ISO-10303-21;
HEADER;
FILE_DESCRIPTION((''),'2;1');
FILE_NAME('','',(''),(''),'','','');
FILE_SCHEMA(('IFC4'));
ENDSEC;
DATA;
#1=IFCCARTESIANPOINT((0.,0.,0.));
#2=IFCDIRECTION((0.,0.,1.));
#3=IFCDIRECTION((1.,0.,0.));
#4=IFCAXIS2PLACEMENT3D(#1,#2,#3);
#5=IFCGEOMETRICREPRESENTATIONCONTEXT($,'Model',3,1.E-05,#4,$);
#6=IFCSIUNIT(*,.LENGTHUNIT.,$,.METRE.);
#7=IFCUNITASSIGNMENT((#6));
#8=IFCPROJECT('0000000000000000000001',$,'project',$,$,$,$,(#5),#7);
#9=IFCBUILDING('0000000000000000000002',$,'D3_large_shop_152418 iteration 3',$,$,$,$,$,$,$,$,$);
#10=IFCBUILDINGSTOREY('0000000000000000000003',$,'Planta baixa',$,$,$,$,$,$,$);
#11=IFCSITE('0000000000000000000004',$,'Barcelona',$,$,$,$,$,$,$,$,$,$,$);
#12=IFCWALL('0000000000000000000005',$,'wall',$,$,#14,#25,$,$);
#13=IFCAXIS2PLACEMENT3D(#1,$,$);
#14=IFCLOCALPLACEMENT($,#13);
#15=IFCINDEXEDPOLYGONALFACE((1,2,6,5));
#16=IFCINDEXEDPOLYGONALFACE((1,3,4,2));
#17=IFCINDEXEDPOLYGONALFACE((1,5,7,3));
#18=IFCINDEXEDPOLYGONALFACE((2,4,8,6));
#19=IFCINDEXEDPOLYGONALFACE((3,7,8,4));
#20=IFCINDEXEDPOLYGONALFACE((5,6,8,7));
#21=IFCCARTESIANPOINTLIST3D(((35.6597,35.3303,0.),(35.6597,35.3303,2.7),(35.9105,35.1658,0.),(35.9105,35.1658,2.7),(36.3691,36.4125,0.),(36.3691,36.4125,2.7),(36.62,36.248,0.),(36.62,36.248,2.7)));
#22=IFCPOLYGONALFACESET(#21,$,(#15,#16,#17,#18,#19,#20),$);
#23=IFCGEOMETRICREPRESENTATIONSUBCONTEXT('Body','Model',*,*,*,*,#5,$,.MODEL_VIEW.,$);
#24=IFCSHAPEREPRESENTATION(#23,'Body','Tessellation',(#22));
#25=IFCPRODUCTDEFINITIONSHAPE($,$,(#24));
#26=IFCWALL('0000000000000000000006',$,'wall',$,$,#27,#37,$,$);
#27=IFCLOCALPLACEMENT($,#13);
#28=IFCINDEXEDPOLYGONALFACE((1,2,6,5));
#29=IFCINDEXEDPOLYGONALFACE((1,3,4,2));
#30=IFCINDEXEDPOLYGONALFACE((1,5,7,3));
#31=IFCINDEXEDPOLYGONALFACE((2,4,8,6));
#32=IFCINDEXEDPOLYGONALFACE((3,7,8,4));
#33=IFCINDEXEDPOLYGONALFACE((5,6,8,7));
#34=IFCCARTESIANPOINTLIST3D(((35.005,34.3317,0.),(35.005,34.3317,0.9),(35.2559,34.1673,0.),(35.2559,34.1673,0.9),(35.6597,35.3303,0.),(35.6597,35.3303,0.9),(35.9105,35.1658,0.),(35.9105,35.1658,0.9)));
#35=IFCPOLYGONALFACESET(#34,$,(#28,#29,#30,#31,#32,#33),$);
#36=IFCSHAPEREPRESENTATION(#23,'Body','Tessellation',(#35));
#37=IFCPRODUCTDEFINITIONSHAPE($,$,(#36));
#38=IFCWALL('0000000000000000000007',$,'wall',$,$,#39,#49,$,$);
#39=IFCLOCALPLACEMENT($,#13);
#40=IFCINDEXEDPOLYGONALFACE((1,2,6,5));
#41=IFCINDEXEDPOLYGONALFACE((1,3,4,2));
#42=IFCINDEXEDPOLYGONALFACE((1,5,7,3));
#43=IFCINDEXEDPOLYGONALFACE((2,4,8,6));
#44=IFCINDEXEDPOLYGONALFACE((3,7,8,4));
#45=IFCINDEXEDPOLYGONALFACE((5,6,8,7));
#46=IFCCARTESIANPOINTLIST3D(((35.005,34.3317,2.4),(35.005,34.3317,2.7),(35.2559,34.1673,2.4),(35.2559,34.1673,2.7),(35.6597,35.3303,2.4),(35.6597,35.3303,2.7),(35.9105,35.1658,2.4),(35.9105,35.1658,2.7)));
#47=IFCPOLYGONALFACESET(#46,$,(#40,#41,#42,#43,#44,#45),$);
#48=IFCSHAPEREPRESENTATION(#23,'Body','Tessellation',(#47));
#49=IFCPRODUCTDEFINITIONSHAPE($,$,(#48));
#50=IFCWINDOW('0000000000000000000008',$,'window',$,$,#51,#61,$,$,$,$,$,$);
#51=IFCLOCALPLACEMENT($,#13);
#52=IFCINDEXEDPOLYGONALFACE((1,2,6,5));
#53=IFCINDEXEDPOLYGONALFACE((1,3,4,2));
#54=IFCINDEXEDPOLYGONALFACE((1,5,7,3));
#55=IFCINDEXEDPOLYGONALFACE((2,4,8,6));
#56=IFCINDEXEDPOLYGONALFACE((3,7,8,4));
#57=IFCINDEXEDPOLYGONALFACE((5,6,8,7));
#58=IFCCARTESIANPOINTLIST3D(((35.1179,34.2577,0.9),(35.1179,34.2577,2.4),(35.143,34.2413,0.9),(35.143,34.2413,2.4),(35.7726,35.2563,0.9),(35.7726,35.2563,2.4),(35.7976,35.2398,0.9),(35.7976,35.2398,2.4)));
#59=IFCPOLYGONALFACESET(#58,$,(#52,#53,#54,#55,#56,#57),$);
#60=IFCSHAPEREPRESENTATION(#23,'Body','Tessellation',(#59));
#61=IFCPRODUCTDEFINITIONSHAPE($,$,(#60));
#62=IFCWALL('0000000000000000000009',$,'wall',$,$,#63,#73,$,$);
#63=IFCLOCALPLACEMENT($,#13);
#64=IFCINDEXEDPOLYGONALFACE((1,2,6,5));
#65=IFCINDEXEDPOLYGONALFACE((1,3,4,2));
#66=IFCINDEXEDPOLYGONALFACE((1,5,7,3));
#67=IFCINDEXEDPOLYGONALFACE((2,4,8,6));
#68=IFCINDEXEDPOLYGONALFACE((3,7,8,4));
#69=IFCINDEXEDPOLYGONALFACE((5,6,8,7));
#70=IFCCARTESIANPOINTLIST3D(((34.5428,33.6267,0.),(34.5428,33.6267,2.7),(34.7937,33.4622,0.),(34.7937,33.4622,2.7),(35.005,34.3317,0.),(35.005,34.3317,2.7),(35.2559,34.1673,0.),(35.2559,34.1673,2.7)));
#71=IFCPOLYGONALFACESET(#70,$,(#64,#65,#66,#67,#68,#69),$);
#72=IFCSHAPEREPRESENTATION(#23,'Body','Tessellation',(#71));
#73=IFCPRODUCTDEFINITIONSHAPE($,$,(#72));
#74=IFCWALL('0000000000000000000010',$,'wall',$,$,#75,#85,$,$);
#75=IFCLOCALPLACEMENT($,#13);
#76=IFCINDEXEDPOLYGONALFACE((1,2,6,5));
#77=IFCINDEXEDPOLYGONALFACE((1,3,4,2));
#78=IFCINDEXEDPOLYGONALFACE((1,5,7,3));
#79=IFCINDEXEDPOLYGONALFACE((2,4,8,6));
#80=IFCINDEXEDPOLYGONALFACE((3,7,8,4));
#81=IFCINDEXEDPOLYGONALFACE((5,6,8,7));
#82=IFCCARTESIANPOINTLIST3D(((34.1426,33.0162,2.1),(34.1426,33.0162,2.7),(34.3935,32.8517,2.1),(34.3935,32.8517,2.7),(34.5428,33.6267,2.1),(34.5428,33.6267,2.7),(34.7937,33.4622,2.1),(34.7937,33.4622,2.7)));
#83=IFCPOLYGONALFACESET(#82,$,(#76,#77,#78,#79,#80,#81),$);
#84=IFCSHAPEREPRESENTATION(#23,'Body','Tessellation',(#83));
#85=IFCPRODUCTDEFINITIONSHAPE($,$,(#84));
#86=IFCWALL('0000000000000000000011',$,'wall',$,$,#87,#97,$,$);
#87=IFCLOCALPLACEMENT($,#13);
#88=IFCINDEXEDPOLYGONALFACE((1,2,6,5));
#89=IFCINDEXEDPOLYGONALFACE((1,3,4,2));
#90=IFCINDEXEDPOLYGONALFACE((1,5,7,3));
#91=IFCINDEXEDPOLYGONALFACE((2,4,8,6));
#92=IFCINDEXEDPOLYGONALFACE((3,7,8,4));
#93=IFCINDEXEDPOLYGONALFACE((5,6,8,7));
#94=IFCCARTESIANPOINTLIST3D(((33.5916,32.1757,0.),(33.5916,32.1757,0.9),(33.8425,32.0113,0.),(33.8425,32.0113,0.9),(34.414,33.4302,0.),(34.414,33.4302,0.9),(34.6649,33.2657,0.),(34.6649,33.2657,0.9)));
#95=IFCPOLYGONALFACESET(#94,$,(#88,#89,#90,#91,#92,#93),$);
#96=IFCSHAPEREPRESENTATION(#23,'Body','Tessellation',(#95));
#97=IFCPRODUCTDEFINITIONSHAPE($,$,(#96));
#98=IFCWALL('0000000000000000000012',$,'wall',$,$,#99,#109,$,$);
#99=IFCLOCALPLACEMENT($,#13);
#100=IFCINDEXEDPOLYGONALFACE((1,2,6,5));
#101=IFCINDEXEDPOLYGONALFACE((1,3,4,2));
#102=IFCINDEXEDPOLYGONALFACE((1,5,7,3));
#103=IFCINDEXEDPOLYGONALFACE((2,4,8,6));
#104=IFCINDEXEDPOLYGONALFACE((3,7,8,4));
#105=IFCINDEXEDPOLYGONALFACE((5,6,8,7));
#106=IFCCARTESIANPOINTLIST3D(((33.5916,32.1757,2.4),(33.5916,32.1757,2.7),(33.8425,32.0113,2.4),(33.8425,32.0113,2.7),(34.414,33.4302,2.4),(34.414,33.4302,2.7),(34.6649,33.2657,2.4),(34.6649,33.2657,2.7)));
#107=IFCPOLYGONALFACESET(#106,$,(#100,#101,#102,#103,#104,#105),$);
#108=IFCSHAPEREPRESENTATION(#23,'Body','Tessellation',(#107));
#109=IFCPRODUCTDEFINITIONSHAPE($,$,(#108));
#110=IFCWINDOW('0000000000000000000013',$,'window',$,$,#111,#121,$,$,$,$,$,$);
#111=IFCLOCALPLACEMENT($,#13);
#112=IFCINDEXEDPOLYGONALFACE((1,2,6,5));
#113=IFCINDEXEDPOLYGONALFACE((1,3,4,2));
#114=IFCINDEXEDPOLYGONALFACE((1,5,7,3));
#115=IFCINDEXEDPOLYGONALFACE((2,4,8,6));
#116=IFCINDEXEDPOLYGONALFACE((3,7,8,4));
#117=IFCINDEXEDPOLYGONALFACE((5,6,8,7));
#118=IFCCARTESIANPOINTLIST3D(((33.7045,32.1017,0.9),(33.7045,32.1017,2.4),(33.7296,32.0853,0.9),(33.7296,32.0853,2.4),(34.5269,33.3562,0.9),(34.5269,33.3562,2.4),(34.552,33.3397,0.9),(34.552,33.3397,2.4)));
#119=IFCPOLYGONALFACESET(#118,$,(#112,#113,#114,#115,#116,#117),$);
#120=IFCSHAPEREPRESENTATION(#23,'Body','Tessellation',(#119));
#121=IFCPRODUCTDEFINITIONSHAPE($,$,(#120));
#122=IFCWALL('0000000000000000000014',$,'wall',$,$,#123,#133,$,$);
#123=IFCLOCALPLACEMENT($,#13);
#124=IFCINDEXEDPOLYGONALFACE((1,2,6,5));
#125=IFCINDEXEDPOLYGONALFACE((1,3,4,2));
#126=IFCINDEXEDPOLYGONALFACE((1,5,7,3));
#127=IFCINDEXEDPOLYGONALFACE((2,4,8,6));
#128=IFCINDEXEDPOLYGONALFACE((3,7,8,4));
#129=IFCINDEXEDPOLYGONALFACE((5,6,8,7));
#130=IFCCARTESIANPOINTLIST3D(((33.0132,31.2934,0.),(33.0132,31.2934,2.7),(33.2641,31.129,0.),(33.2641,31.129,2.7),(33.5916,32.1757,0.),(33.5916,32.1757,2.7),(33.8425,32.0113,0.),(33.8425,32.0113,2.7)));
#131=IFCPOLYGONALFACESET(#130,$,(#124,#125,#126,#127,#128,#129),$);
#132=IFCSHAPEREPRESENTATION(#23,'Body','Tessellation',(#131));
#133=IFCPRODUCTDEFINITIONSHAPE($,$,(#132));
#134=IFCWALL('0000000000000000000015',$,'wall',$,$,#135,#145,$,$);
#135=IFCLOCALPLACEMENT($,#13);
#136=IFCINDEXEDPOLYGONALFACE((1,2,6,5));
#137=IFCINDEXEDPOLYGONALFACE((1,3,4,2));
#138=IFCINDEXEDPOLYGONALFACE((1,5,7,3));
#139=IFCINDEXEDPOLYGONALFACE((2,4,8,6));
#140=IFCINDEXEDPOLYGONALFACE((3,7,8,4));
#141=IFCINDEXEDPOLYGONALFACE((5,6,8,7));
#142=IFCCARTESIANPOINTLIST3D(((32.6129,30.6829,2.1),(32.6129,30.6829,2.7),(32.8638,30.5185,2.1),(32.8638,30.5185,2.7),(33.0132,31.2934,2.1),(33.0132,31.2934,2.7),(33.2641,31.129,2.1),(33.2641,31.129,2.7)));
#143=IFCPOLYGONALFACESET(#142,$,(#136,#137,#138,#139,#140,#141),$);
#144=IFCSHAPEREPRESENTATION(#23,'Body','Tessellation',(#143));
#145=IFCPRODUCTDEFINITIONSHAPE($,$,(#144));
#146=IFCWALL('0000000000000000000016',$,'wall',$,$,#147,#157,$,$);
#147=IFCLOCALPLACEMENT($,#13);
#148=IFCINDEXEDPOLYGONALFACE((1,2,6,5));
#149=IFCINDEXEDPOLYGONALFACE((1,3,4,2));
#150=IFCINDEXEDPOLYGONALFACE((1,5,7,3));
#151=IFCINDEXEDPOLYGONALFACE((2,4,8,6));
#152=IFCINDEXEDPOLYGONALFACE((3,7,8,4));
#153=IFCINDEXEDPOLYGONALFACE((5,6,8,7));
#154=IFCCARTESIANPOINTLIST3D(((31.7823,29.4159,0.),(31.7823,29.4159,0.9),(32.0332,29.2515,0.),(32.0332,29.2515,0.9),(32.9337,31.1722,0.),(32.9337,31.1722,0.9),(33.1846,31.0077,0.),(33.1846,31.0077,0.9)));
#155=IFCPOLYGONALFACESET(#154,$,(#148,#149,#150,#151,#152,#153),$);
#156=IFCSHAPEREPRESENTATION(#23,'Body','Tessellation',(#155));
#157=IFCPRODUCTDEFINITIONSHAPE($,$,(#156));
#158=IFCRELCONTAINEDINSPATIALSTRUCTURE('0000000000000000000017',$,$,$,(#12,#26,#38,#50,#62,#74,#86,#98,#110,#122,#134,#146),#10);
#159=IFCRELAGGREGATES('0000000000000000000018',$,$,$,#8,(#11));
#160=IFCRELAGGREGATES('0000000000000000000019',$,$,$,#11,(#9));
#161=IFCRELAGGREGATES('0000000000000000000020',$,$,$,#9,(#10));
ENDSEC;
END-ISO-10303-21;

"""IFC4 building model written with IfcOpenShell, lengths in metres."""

from ifc_helpers import new_model, si_unit, frame, origin, origin_with_axes, place, context, subcontext, project, spatial, polyline, outline, extrude, element, save


model = new_model("IFC4")

# Units and contexts
model_context = context("Model", 3, precision=1e-05, world=origin_with_axes())
body_context = subcontext(model_context, "Body", "Model", "MODEL_VIEW")
ifc_project = project(units=[si_unit("LENGTHUNIT", "METRE")], contexts=[model_context])

# Site, building, storey
site = spatial("IfcSite", under=ifc_project, Name="Barcelona")
building = spatial("IfcBuilding", under=site, Name="D3_large_shop_152418 iteration 3")
storey = spatial("IfcBuildingStorey", under=building, Name="Planta baixa")

# Walls
wall_1_placement = place(None, origin_with_axes())
element("IfcWall", 1, at=wall_1_placement, inside=storey, Name="wall", context=body_context, shape_type="SweptSolid", body=[
    extrude(outline(polyline([(36.62, 36.248), (35.9105, 35.1658), (35.6597, 35.3303), (36.3691, 36.4125), (36.62, 36.248)])), origin(), (0.0, 0.0, 1.0), 2.7),
])
wall_2_placement = place(None, origin_with_axes())
element("IfcWall", 2, at=wall_2_placement, inside=storey, Name="wall", context=body_context, shape_type="SweptSolid", body=[
    extrude(outline(polyline([(35.9105, 35.1658), (35.2559, 34.1673), (35.005, 34.3317), (35.6597, 35.3303), (35.9105, 35.1658)])), origin(), (0.0, 0.0, 1.0), 0.9),
])
wall_3_placement = place(None, origin_with_axes())
element("IfcWall", 3, at=wall_3_placement, inside=storey, Name="wall", context=body_context, shape_type="SweptSolid", body=[
    extrude(outline(polyline([(35.9105, 35.1658), (35.2559, 34.1673), (35.005, 34.3317), (35.6597, 35.3303), (35.9105, 35.1658)])), frame((0.0, 0.0, 2.4)), (0.0, 0.0, 1.0), 0.3),
])

# Window
window_1_placement = place(None, origin_with_axes())
element("IfcWindow", 4, at=window_1_placement, inside=storey, Name="window", context=body_context, shape_type="SweptSolid", body=[
    extrude(outline(polyline([(35.7976, 35.2398), (35.143, 34.2413), (35.1179, 34.2577), (35.7726, 35.2563), (35.7976, 35.2398)])), frame((0.0, 0.0, 0.9)), (0.0, 0.0, 1.0), 1.5),
])

# Walls
wall_4_placement = place(None, origin_with_axes())
element("IfcWall", 5, at=wall_4_placement, inside=storey, Name="wall", context=body_context, shape_type="SweptSolid", body=[
    extrude(outline(polyline([(35.2559, 34.1673), (34.7937, 33.4622), (34.5428, 33.6267), (35.005, 34.3317), (35.2559, 34.1673)])), origin(), (0.0, 0.0, 1.0), 2.7),
])
wall_5_placement = place(None, origin_with_axes())
element("IfcWall", 6, at=wall_5_placement, inside=storey, Name="wall", context=body_context, shape_type="SweptSolid", body=[
    extrude(outline(polyline([(34.7937, 33.4622), (34.3935, 32.8517), (34.1426, 33.0162), (34.5428, 33.6267), (34.7937, 33.4622)])), frame((0.0, 0.0, 2.1)), (0.0, 0.0, 1.0), 0.6),
])
wall_6_placement = place(None, origin_with_axes())
element("IfcWall", 7, at=wall_6_placement, inside=storey, Name="wall", context=body_context, shape_type="SweptSolid", body=[
    extrude(outline(polyline([(34.6649, 33.2657), (33.8425, 32.0113), (33.5916, 32.1757), (34.414, 33.4302), (34.6649, 33.2657)])), origin(), (0.0, 0.0, 1.0), 0.9),
])
wall_7_placement = place(None, origin_with_axes())
element("IfcWall", 8, at=wall_7_placement, inside=storey, Name="wall", context=body_context, shape_type="SweptSolid", body=[
    extrude(outline(polyline([(34.6649, 33.2657), (33.8425, 32.0113), (33.5916, 32.1757), (34.414, 33.4302), (34.6649, 33.2657)])), frame((0.0, 0.0, 2.4)), (0.0, 0.0, 1.0), 0.3),
])

# Window
window_2_placement = place(None, origin_with_axes())
element("IfcWindow", 9, at=window_2_placement, inside=storey, Name="window", context=body_context, shape_type="SweptSolid", body=[
    extrude(outline(polyline([(34.552, 33.3397), (33.7296, 32.0853), (33.7045, 32.1017), (34.5269, 33.3562), (34.552, 33.3397)])), frame((0.0, 0.0, 0.9)), (0.0, 0.0, 1.0), 1.5),
])

# Walls
wall_8_placement = place(None, origin_with_axes())
element("IfcWall", 10, at=wall_8_placement, inside=storey, Name="wall", context=body_context, shape_type="SweptSolid", body=[
    extrude(outline(polyline([(33.8425, 32.0113), (33.2641, 31.129), (33.0132, 31.2934), (33.5916, 32.1757), (33.8425, 32.0113)])), origin(), (0.0, 0.0, 1.0), 2.7),
])
wall_9_placement = place(None, origin_with_axes())
element("IfcWall", 11, at=wall_9_placement, inside=storey, Name="wall", context=body_context, shape_type="SweptSolid", body=[
    extrude(outline(polyline([(33.2641, 31.129), (32.8638, 30.5185), (32.6129, 30.6829), (33.0132, 31.2934), (33.2641, 31.129)])), frame((0.0, 0.0, 2.1)), (0.0, 0.0, 1.0), 0.6),
])
wall_10_placement = place(None, origin_with_axes())
element("IfcWall", 12, at=wall_10_placement, inside=storey, Name="wall", context=body_context, shape_type="SweptSolid", body=[
    extrude(outline(polyline([(33.1846, 31.0077), (32.0332, 29.2515), (31.7823, 29.4159), (32.9337, 31.1722), (33.1846, 31.0077)])), origin(), (0.0, 0.0, 1.0), 0.9),
])

save(model, "model.ifc")
